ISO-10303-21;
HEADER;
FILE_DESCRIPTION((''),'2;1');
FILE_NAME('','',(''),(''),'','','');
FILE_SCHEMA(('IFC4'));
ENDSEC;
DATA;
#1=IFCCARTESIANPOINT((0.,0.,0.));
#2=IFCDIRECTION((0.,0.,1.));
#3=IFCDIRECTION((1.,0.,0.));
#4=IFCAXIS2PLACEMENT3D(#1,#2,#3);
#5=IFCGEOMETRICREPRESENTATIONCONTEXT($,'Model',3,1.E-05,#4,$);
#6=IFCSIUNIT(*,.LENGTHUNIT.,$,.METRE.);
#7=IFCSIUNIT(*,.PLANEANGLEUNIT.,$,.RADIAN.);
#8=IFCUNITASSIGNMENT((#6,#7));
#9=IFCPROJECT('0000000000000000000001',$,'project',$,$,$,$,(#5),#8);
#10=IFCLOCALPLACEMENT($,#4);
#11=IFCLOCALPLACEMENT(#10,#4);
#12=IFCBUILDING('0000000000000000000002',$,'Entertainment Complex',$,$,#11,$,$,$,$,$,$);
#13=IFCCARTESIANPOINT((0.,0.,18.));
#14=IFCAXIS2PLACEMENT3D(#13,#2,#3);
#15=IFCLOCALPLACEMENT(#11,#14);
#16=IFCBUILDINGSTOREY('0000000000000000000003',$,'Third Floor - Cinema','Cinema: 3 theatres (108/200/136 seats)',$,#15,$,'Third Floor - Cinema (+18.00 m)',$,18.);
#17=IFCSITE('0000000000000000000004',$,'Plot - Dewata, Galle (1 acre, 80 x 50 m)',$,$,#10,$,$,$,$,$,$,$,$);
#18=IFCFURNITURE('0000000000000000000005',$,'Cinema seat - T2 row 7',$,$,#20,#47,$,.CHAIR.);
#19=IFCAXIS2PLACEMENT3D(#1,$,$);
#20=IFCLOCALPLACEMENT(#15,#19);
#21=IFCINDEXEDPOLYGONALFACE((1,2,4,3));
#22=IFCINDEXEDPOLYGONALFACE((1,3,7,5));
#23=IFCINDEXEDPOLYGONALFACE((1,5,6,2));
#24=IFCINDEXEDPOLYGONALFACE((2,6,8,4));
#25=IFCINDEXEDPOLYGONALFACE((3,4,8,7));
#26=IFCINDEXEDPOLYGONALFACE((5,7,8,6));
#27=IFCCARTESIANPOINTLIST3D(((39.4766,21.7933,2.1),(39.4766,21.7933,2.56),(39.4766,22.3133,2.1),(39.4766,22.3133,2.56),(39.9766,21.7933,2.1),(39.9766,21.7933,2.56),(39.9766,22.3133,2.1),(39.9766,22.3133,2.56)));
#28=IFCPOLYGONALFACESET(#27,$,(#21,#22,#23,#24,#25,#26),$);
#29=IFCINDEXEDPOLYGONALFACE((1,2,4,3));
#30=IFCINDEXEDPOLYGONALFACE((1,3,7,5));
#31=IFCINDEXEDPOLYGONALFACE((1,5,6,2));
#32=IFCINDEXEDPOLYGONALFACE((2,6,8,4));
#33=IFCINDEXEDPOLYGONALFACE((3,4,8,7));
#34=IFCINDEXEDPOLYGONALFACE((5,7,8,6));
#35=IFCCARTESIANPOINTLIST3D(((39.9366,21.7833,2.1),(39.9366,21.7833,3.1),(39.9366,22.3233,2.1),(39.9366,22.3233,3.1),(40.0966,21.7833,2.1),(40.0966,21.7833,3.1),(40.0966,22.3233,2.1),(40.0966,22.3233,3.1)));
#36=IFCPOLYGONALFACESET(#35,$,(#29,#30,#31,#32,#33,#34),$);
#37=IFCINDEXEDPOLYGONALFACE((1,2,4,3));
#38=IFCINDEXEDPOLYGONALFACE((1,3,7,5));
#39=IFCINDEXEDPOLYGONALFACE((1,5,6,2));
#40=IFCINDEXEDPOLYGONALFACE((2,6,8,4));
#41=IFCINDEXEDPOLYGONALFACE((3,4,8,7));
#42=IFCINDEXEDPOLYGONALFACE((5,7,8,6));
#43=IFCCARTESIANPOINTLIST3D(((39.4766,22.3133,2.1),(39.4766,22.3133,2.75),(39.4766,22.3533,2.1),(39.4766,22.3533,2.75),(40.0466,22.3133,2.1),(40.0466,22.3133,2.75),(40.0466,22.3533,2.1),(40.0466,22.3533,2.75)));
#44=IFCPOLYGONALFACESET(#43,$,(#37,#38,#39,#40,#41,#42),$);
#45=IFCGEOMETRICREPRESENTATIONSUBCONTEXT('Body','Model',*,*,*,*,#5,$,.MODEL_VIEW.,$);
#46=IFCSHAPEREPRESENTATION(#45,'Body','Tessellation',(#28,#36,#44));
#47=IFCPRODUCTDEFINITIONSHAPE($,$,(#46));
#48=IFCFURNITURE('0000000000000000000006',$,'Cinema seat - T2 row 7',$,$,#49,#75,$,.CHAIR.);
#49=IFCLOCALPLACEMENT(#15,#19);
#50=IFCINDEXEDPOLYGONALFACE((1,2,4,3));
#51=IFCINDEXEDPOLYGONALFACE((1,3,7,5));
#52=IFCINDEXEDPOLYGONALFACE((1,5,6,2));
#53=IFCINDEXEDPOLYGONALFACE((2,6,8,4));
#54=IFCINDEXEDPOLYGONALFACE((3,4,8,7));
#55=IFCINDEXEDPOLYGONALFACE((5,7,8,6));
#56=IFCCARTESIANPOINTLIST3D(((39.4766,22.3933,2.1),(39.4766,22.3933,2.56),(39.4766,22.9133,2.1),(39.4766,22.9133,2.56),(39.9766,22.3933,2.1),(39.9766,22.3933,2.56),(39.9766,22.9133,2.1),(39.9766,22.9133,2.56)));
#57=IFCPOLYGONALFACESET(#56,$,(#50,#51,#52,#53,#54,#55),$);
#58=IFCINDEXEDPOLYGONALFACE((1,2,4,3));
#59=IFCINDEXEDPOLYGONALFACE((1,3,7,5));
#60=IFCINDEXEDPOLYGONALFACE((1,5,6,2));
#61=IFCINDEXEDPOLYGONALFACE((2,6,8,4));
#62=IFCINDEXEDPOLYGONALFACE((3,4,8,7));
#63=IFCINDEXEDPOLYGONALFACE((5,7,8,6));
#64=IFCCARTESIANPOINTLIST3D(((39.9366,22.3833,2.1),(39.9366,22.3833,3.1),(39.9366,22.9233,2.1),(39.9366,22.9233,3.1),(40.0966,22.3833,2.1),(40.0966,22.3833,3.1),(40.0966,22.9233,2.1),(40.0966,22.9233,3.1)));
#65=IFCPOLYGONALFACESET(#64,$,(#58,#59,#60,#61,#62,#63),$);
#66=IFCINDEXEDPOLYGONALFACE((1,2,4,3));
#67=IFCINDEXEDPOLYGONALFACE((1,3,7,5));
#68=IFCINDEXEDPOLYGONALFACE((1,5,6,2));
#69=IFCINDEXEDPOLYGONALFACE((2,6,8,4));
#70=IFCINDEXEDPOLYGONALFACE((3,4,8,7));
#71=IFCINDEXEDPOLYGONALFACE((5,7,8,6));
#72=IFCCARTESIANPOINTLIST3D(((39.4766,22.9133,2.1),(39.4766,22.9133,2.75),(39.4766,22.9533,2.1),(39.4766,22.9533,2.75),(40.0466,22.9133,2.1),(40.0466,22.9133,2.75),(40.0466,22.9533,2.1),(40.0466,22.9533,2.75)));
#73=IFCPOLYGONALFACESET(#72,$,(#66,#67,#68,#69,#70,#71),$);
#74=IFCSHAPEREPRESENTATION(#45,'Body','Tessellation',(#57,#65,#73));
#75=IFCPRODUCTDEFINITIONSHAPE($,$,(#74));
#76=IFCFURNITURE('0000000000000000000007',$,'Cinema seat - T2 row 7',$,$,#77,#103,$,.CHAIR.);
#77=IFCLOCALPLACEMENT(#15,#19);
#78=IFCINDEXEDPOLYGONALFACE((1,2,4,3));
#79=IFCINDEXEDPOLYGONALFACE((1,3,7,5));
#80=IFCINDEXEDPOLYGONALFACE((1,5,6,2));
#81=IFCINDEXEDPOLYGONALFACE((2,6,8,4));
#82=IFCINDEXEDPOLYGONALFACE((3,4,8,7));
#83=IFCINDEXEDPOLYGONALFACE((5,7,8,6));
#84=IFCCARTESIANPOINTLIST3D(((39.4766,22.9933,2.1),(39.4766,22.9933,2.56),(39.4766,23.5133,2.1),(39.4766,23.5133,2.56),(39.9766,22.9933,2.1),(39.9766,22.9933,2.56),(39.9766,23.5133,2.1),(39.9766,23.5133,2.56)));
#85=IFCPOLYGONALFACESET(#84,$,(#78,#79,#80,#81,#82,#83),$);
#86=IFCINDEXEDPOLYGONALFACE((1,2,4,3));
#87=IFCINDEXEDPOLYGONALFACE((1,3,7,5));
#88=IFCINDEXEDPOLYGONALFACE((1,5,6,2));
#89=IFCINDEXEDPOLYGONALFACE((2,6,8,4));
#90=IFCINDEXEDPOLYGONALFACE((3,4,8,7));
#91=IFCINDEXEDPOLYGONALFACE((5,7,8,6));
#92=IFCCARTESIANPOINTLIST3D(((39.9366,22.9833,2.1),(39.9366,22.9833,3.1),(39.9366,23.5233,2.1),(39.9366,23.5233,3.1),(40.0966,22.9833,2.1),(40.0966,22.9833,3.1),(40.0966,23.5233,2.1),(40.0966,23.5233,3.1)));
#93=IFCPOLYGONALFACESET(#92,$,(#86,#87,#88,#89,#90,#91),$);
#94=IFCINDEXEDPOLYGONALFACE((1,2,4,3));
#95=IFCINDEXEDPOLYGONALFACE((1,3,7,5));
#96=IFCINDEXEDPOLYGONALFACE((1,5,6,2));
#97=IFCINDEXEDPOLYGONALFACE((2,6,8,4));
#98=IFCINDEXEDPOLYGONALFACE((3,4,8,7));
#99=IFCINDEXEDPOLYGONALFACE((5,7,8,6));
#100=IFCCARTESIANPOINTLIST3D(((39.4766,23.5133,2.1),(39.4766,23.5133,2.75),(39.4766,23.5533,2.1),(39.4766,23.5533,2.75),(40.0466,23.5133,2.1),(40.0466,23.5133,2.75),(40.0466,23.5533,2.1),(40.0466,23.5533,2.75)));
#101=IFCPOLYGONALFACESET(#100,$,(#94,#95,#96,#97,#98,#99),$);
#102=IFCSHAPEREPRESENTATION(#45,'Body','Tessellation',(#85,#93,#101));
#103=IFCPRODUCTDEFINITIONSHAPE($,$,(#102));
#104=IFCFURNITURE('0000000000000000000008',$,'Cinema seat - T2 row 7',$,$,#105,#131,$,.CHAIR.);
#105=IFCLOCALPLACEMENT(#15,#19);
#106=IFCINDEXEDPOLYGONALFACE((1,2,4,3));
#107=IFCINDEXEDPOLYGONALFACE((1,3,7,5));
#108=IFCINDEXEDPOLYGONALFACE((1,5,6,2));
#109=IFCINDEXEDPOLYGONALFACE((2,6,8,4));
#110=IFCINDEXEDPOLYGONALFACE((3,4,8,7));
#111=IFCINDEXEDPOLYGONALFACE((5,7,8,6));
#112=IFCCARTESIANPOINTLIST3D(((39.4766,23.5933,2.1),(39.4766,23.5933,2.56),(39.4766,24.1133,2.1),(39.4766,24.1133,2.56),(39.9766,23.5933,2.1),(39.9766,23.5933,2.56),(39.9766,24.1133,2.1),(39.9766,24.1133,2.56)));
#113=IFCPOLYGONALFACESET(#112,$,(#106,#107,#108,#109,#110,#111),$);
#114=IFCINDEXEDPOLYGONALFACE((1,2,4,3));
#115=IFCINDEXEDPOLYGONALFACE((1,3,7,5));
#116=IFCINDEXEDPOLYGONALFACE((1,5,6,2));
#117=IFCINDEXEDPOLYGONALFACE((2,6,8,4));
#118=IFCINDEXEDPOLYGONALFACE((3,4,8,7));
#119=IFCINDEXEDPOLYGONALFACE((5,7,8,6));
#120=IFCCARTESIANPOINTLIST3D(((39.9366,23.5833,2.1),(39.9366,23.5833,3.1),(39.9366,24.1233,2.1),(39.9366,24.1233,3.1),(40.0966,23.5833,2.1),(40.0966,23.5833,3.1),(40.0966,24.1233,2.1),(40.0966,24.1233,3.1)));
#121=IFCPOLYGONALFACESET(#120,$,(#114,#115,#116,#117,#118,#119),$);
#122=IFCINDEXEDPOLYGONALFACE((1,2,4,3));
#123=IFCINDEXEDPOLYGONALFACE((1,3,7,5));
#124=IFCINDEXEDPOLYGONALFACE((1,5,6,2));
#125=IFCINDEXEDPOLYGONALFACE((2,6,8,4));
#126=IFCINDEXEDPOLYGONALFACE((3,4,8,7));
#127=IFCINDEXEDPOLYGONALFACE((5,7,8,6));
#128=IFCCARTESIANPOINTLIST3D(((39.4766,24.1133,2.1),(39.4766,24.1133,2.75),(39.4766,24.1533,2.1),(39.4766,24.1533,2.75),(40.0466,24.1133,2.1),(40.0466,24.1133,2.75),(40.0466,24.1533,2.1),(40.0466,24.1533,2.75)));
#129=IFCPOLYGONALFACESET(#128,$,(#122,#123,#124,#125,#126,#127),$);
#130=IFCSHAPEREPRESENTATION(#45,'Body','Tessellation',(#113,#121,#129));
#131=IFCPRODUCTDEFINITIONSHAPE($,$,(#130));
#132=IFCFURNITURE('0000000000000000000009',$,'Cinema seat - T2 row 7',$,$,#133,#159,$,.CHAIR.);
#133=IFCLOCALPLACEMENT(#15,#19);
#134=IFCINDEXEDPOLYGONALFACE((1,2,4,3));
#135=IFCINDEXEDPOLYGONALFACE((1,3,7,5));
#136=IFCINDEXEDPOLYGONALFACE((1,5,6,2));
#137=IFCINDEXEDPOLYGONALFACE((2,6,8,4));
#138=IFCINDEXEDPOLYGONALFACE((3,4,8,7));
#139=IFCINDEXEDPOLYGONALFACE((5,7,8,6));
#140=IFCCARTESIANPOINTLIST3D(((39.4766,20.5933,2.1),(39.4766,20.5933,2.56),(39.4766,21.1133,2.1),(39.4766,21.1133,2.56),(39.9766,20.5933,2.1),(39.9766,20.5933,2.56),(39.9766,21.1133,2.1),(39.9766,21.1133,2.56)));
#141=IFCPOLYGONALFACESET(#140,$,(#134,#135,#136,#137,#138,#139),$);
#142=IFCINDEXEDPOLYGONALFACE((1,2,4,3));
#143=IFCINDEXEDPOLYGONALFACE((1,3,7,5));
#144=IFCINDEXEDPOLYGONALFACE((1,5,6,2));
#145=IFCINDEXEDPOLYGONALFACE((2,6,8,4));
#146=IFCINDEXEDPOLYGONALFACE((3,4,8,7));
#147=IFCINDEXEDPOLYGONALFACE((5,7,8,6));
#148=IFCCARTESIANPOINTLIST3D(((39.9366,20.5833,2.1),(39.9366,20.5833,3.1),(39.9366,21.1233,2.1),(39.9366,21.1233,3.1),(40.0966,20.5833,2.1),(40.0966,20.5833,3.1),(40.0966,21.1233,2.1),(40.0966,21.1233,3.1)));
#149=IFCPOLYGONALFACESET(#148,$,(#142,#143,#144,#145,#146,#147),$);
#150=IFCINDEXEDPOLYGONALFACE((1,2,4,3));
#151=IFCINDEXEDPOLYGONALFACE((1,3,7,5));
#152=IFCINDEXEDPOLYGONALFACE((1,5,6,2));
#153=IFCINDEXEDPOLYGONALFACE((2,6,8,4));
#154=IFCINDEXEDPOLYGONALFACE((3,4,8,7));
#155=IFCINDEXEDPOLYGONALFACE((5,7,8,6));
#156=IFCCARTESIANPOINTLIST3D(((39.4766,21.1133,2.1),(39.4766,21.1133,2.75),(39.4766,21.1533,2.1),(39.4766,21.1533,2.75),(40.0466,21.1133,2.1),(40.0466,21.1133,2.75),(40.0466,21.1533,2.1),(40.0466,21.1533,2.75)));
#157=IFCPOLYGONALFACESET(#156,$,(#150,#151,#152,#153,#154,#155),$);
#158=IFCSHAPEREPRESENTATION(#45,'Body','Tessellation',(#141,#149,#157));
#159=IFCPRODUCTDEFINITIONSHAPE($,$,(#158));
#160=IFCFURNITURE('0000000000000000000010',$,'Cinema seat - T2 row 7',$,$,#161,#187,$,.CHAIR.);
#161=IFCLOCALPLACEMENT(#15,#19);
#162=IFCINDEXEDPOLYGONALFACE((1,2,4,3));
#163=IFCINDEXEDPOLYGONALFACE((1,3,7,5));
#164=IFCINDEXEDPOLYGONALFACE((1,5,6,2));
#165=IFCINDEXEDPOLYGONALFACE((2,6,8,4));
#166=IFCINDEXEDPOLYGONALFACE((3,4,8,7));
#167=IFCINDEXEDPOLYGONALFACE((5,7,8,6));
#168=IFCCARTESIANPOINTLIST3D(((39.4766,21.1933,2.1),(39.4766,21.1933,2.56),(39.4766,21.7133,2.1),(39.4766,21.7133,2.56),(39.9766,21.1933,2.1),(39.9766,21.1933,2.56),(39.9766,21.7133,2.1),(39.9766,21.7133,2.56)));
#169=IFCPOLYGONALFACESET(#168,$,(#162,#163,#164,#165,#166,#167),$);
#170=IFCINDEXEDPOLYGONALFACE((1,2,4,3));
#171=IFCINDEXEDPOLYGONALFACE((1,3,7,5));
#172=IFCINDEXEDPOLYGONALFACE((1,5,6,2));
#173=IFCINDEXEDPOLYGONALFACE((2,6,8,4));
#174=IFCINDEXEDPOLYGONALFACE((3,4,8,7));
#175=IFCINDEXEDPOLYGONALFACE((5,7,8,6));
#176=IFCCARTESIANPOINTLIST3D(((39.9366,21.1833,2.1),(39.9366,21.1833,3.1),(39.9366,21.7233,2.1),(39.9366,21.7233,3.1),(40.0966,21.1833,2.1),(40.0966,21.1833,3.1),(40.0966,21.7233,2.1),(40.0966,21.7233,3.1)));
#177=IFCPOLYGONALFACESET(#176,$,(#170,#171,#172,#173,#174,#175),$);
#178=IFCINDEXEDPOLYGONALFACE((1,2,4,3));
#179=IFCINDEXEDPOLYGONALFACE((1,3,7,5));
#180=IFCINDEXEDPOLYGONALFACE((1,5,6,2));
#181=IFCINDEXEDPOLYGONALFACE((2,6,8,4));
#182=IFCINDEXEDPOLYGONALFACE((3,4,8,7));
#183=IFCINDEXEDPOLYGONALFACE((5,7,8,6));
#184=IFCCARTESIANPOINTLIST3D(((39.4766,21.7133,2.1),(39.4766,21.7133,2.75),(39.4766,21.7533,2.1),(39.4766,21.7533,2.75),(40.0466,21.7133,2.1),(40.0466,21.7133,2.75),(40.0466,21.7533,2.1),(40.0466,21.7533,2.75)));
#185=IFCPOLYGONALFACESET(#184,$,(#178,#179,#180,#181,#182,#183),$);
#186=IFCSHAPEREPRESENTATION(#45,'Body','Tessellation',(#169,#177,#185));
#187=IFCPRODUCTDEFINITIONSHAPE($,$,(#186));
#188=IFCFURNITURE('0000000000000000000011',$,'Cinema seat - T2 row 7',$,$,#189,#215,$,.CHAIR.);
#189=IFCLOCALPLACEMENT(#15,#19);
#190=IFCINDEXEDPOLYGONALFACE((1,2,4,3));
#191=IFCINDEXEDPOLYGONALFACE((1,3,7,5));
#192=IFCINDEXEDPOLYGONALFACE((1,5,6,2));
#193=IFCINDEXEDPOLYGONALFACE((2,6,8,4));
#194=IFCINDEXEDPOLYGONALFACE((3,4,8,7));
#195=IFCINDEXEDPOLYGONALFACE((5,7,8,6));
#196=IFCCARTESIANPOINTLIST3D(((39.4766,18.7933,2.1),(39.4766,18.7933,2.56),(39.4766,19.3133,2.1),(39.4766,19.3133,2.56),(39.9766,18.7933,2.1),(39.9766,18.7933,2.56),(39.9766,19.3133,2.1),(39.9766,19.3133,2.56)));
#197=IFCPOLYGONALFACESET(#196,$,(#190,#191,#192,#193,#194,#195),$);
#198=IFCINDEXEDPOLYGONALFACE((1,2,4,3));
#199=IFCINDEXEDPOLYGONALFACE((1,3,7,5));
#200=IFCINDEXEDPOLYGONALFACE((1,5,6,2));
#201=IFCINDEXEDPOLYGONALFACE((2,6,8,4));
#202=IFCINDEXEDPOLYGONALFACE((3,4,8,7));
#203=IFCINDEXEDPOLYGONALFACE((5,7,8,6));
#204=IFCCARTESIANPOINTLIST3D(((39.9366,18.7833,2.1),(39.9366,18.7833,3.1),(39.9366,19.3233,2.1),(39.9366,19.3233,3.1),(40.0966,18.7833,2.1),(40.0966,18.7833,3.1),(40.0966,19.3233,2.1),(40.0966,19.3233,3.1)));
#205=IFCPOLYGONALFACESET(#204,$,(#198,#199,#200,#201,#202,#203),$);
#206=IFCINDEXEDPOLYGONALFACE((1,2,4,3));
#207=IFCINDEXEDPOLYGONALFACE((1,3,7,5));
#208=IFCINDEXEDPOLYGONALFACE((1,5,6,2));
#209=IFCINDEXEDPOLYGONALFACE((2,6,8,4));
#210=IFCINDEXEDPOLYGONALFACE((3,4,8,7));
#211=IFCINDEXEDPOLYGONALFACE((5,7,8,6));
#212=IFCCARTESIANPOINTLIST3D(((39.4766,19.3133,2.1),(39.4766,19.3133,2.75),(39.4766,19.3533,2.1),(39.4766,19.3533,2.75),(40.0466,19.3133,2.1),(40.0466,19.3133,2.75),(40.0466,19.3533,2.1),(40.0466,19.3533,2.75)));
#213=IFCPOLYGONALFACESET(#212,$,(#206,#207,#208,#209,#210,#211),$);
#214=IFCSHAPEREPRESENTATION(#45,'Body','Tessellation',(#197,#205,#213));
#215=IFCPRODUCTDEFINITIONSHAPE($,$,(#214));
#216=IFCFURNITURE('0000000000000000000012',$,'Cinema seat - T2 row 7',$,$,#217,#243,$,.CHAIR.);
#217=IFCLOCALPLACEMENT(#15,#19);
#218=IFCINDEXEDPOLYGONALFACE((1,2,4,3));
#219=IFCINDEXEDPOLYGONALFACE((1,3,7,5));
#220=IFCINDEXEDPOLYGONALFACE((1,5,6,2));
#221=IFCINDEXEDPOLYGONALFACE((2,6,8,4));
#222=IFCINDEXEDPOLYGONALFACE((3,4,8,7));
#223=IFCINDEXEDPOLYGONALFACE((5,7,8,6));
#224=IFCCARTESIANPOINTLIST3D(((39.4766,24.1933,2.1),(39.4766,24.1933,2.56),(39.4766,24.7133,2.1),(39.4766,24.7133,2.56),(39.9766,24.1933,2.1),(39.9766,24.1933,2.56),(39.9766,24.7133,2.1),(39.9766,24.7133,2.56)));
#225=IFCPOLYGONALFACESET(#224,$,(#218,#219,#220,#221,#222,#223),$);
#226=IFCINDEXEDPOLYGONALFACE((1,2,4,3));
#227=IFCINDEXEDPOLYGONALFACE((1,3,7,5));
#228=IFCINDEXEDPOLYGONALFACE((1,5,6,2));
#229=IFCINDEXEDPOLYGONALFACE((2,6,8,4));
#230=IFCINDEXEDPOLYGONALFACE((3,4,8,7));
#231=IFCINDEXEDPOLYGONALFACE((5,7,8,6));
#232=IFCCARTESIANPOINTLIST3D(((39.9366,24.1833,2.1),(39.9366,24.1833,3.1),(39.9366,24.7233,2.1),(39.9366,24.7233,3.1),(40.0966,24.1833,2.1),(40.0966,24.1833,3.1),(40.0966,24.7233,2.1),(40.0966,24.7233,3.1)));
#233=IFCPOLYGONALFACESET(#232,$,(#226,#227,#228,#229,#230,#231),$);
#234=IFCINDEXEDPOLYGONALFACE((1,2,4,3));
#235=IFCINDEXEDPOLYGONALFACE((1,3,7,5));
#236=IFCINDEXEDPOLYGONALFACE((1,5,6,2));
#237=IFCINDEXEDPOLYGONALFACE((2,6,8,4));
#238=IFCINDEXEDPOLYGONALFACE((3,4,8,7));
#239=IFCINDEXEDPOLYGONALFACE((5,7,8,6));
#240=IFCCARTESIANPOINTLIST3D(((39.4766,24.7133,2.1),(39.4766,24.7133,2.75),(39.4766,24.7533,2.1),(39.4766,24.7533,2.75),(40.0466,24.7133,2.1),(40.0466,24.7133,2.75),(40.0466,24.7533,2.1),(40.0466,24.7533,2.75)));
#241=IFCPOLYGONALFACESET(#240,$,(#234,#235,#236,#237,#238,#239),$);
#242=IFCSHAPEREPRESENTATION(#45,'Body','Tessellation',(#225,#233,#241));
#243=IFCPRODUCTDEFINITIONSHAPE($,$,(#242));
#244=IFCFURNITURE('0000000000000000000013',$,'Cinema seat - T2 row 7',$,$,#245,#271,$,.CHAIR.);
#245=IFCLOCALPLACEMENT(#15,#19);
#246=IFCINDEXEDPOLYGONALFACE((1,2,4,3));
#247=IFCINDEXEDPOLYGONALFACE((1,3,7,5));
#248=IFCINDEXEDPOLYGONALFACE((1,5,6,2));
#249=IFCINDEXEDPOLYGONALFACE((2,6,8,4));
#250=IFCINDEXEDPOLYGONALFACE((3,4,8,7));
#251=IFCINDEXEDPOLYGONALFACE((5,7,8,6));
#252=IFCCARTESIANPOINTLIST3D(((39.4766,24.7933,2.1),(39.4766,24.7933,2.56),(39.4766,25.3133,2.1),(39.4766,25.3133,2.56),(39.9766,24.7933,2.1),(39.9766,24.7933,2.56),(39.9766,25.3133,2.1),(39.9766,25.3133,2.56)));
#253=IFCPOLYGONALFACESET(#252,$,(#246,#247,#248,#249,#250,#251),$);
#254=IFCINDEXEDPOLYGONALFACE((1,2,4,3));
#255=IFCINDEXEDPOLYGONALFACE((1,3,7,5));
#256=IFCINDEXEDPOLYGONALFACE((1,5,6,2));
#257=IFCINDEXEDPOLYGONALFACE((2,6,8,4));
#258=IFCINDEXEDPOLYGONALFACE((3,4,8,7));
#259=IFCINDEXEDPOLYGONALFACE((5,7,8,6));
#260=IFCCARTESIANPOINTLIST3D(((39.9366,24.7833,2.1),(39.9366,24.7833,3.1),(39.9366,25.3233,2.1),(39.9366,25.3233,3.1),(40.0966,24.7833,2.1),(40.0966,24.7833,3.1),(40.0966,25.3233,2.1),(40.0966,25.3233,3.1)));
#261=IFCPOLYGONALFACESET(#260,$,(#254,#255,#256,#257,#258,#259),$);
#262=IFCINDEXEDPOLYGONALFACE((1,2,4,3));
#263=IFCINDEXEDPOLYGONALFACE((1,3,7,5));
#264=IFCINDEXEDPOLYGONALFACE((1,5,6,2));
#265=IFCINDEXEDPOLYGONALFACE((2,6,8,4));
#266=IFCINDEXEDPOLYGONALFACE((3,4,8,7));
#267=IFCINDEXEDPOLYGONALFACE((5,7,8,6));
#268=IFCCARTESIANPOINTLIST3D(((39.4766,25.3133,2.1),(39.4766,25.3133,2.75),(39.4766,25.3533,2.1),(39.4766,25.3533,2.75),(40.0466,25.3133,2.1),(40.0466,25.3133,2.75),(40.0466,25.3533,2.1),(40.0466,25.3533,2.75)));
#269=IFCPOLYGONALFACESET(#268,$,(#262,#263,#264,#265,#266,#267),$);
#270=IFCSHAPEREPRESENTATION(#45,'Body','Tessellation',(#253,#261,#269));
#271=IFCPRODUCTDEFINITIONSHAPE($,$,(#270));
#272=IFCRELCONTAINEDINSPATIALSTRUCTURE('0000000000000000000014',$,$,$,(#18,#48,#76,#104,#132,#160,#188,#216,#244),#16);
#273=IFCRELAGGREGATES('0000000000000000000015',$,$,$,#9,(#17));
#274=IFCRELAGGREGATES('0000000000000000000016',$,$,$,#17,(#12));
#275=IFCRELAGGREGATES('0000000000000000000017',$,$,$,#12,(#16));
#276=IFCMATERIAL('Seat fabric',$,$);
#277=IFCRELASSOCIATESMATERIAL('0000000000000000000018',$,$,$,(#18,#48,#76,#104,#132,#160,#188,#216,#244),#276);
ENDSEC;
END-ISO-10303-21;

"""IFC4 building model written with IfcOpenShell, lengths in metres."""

from ifc_helpers import new_model, si_unit, frame, origin_with_axes, place, context, subcontext, project, spatial, polyline, outline, extrude, material, element, save


model = new_model("IFC4")

# Units and contexts
model_context = context("Model", 3, precision=1e-05, world=origin_with_axes())
body_context = subcontext(model_context, "Body", "Model", "MODEL_VIEW")
ifc_project = project(units=[si_unit("LENGTHUNIT", "METRE"), si_unit("PLANEANGLEUNIT", "RADIAN")], contexts=[model_context])

# Site, building, storey
site_placement = place(None, origin_with_axes())
site = spatial("IfcSite", under=ifc_project, at=site_placement, Name="Plot - Dewata, Galle (1 acre, 80 x 50 m)")
building_placement = place(site_placement, origin_with_axes())
building = spatial("IfcBuilding", under=site, at=building_placement, Name="Entertainment Complex")
storey_placement = place(building_placement, frame((0.0, 0.0, 18.0), z_axis=(0.0, 0.0, 1.0), x_axis=(1.0, 0.0, 0.0)))
storey = spatial("IfcBuildingStorey", under=building, at=storey_placement, Name="Third Floor - Cinema", Description="Cinema: 3 theatres (108/200/136 seats)", LongName="Third Floor - Cinema (+18.00 m)", Elevation=18.0)

# Furniture
ifc_material_1 = material(Name="Seat fabric")
for number, where, z_axis, x_axis, name in (
    (1, (40.0966, 22.0533, 2.1), (0.0, 0.0, 1.0), (1.0, 0.0, 0.0), "Cinema seat - T2 row 7"),
    (2, (40.0966, 22.6533, 2.1), (0.0, 0.0, 1.0), (1.0, 0.0, 0.0), "Cinema seat - T2 row 7"),
    (3, (40.0966, 23.2533, 2.1), (0.0, 0.0, 1.0), (1.0, 0.0, 0.0), "Cinema seat - T2 row 7"),
    (4, (40.0966, 23.8533, 2.1), (0.0, 0.0, 1.0), (1.0, 0.0, 0.0), "Cinema seat - T2 row 7"),
    (5, (40.0966, 20.8533, 2.1), (0.0, 0.0, 1.0), (1.0, 0.0, 0.0), "Cinema seat - T2 row 7"),
    (6, (40.0966, 21.4533, 2.1), (0.0, 0.0, 1.0), (1.0, 0.0, 0.0), "Cinema seat - T2 row 7"),
    (7, (40.0966, 19.0533, 2.1), (0.0, 0.0, 1.0), (1.0, 0.0, 0.0), "Cinema seat - T2 row 7"),
    (8, (40.0966, 24.4533, 2.1), (0.0, 0.0, 1.0), (1.0, 0.0, 0.0), "Cinema seat - T2 row 7"),
    (9, (40.0966, 25.0533, 2.1), (0.0, 0.0, 1.0), (1.0, 0.0, 0.0), "Cinema seat - T2 row 7"),
):
    element("IfcFurniture", number, at=place(storey_placement, frame(where, z_axis=z_axis, x_axis=x_axis)), inside=storey, material=ifc_material_1, Name=name, PredefinedType="CHAIR", context=body_context, shape_type="SweptSolid", body=[
        extrude(outline(polyline([(-0.62, -0.26), (-0.12, -0.26), (-0.12, 0.26), (-0.62, 0.26), (-0.62, -0.26)])), origin_with_axes(), (0.0, 0.0, 1.0), 0.46),
        extrude(outline(polyline([(-0.16, -0.27), (0.0, -0.27), (0.0, 0.27), (-0.16, 0.27), (-0.16, -0.27)])), origin_with_axes(), (0.0, 0.0, 1.0), 1.0),
        extrude(outline(polyline([(-0.62, 0.26), (-0.05, 0.26), (-0.05, 0.3), (-0.62, 0.3), (-0.62, 0.26)])), origin_with_axes(), (0.0, 0.0, 1.0), 0.65),
    ])

save(model, "model.ifc")
